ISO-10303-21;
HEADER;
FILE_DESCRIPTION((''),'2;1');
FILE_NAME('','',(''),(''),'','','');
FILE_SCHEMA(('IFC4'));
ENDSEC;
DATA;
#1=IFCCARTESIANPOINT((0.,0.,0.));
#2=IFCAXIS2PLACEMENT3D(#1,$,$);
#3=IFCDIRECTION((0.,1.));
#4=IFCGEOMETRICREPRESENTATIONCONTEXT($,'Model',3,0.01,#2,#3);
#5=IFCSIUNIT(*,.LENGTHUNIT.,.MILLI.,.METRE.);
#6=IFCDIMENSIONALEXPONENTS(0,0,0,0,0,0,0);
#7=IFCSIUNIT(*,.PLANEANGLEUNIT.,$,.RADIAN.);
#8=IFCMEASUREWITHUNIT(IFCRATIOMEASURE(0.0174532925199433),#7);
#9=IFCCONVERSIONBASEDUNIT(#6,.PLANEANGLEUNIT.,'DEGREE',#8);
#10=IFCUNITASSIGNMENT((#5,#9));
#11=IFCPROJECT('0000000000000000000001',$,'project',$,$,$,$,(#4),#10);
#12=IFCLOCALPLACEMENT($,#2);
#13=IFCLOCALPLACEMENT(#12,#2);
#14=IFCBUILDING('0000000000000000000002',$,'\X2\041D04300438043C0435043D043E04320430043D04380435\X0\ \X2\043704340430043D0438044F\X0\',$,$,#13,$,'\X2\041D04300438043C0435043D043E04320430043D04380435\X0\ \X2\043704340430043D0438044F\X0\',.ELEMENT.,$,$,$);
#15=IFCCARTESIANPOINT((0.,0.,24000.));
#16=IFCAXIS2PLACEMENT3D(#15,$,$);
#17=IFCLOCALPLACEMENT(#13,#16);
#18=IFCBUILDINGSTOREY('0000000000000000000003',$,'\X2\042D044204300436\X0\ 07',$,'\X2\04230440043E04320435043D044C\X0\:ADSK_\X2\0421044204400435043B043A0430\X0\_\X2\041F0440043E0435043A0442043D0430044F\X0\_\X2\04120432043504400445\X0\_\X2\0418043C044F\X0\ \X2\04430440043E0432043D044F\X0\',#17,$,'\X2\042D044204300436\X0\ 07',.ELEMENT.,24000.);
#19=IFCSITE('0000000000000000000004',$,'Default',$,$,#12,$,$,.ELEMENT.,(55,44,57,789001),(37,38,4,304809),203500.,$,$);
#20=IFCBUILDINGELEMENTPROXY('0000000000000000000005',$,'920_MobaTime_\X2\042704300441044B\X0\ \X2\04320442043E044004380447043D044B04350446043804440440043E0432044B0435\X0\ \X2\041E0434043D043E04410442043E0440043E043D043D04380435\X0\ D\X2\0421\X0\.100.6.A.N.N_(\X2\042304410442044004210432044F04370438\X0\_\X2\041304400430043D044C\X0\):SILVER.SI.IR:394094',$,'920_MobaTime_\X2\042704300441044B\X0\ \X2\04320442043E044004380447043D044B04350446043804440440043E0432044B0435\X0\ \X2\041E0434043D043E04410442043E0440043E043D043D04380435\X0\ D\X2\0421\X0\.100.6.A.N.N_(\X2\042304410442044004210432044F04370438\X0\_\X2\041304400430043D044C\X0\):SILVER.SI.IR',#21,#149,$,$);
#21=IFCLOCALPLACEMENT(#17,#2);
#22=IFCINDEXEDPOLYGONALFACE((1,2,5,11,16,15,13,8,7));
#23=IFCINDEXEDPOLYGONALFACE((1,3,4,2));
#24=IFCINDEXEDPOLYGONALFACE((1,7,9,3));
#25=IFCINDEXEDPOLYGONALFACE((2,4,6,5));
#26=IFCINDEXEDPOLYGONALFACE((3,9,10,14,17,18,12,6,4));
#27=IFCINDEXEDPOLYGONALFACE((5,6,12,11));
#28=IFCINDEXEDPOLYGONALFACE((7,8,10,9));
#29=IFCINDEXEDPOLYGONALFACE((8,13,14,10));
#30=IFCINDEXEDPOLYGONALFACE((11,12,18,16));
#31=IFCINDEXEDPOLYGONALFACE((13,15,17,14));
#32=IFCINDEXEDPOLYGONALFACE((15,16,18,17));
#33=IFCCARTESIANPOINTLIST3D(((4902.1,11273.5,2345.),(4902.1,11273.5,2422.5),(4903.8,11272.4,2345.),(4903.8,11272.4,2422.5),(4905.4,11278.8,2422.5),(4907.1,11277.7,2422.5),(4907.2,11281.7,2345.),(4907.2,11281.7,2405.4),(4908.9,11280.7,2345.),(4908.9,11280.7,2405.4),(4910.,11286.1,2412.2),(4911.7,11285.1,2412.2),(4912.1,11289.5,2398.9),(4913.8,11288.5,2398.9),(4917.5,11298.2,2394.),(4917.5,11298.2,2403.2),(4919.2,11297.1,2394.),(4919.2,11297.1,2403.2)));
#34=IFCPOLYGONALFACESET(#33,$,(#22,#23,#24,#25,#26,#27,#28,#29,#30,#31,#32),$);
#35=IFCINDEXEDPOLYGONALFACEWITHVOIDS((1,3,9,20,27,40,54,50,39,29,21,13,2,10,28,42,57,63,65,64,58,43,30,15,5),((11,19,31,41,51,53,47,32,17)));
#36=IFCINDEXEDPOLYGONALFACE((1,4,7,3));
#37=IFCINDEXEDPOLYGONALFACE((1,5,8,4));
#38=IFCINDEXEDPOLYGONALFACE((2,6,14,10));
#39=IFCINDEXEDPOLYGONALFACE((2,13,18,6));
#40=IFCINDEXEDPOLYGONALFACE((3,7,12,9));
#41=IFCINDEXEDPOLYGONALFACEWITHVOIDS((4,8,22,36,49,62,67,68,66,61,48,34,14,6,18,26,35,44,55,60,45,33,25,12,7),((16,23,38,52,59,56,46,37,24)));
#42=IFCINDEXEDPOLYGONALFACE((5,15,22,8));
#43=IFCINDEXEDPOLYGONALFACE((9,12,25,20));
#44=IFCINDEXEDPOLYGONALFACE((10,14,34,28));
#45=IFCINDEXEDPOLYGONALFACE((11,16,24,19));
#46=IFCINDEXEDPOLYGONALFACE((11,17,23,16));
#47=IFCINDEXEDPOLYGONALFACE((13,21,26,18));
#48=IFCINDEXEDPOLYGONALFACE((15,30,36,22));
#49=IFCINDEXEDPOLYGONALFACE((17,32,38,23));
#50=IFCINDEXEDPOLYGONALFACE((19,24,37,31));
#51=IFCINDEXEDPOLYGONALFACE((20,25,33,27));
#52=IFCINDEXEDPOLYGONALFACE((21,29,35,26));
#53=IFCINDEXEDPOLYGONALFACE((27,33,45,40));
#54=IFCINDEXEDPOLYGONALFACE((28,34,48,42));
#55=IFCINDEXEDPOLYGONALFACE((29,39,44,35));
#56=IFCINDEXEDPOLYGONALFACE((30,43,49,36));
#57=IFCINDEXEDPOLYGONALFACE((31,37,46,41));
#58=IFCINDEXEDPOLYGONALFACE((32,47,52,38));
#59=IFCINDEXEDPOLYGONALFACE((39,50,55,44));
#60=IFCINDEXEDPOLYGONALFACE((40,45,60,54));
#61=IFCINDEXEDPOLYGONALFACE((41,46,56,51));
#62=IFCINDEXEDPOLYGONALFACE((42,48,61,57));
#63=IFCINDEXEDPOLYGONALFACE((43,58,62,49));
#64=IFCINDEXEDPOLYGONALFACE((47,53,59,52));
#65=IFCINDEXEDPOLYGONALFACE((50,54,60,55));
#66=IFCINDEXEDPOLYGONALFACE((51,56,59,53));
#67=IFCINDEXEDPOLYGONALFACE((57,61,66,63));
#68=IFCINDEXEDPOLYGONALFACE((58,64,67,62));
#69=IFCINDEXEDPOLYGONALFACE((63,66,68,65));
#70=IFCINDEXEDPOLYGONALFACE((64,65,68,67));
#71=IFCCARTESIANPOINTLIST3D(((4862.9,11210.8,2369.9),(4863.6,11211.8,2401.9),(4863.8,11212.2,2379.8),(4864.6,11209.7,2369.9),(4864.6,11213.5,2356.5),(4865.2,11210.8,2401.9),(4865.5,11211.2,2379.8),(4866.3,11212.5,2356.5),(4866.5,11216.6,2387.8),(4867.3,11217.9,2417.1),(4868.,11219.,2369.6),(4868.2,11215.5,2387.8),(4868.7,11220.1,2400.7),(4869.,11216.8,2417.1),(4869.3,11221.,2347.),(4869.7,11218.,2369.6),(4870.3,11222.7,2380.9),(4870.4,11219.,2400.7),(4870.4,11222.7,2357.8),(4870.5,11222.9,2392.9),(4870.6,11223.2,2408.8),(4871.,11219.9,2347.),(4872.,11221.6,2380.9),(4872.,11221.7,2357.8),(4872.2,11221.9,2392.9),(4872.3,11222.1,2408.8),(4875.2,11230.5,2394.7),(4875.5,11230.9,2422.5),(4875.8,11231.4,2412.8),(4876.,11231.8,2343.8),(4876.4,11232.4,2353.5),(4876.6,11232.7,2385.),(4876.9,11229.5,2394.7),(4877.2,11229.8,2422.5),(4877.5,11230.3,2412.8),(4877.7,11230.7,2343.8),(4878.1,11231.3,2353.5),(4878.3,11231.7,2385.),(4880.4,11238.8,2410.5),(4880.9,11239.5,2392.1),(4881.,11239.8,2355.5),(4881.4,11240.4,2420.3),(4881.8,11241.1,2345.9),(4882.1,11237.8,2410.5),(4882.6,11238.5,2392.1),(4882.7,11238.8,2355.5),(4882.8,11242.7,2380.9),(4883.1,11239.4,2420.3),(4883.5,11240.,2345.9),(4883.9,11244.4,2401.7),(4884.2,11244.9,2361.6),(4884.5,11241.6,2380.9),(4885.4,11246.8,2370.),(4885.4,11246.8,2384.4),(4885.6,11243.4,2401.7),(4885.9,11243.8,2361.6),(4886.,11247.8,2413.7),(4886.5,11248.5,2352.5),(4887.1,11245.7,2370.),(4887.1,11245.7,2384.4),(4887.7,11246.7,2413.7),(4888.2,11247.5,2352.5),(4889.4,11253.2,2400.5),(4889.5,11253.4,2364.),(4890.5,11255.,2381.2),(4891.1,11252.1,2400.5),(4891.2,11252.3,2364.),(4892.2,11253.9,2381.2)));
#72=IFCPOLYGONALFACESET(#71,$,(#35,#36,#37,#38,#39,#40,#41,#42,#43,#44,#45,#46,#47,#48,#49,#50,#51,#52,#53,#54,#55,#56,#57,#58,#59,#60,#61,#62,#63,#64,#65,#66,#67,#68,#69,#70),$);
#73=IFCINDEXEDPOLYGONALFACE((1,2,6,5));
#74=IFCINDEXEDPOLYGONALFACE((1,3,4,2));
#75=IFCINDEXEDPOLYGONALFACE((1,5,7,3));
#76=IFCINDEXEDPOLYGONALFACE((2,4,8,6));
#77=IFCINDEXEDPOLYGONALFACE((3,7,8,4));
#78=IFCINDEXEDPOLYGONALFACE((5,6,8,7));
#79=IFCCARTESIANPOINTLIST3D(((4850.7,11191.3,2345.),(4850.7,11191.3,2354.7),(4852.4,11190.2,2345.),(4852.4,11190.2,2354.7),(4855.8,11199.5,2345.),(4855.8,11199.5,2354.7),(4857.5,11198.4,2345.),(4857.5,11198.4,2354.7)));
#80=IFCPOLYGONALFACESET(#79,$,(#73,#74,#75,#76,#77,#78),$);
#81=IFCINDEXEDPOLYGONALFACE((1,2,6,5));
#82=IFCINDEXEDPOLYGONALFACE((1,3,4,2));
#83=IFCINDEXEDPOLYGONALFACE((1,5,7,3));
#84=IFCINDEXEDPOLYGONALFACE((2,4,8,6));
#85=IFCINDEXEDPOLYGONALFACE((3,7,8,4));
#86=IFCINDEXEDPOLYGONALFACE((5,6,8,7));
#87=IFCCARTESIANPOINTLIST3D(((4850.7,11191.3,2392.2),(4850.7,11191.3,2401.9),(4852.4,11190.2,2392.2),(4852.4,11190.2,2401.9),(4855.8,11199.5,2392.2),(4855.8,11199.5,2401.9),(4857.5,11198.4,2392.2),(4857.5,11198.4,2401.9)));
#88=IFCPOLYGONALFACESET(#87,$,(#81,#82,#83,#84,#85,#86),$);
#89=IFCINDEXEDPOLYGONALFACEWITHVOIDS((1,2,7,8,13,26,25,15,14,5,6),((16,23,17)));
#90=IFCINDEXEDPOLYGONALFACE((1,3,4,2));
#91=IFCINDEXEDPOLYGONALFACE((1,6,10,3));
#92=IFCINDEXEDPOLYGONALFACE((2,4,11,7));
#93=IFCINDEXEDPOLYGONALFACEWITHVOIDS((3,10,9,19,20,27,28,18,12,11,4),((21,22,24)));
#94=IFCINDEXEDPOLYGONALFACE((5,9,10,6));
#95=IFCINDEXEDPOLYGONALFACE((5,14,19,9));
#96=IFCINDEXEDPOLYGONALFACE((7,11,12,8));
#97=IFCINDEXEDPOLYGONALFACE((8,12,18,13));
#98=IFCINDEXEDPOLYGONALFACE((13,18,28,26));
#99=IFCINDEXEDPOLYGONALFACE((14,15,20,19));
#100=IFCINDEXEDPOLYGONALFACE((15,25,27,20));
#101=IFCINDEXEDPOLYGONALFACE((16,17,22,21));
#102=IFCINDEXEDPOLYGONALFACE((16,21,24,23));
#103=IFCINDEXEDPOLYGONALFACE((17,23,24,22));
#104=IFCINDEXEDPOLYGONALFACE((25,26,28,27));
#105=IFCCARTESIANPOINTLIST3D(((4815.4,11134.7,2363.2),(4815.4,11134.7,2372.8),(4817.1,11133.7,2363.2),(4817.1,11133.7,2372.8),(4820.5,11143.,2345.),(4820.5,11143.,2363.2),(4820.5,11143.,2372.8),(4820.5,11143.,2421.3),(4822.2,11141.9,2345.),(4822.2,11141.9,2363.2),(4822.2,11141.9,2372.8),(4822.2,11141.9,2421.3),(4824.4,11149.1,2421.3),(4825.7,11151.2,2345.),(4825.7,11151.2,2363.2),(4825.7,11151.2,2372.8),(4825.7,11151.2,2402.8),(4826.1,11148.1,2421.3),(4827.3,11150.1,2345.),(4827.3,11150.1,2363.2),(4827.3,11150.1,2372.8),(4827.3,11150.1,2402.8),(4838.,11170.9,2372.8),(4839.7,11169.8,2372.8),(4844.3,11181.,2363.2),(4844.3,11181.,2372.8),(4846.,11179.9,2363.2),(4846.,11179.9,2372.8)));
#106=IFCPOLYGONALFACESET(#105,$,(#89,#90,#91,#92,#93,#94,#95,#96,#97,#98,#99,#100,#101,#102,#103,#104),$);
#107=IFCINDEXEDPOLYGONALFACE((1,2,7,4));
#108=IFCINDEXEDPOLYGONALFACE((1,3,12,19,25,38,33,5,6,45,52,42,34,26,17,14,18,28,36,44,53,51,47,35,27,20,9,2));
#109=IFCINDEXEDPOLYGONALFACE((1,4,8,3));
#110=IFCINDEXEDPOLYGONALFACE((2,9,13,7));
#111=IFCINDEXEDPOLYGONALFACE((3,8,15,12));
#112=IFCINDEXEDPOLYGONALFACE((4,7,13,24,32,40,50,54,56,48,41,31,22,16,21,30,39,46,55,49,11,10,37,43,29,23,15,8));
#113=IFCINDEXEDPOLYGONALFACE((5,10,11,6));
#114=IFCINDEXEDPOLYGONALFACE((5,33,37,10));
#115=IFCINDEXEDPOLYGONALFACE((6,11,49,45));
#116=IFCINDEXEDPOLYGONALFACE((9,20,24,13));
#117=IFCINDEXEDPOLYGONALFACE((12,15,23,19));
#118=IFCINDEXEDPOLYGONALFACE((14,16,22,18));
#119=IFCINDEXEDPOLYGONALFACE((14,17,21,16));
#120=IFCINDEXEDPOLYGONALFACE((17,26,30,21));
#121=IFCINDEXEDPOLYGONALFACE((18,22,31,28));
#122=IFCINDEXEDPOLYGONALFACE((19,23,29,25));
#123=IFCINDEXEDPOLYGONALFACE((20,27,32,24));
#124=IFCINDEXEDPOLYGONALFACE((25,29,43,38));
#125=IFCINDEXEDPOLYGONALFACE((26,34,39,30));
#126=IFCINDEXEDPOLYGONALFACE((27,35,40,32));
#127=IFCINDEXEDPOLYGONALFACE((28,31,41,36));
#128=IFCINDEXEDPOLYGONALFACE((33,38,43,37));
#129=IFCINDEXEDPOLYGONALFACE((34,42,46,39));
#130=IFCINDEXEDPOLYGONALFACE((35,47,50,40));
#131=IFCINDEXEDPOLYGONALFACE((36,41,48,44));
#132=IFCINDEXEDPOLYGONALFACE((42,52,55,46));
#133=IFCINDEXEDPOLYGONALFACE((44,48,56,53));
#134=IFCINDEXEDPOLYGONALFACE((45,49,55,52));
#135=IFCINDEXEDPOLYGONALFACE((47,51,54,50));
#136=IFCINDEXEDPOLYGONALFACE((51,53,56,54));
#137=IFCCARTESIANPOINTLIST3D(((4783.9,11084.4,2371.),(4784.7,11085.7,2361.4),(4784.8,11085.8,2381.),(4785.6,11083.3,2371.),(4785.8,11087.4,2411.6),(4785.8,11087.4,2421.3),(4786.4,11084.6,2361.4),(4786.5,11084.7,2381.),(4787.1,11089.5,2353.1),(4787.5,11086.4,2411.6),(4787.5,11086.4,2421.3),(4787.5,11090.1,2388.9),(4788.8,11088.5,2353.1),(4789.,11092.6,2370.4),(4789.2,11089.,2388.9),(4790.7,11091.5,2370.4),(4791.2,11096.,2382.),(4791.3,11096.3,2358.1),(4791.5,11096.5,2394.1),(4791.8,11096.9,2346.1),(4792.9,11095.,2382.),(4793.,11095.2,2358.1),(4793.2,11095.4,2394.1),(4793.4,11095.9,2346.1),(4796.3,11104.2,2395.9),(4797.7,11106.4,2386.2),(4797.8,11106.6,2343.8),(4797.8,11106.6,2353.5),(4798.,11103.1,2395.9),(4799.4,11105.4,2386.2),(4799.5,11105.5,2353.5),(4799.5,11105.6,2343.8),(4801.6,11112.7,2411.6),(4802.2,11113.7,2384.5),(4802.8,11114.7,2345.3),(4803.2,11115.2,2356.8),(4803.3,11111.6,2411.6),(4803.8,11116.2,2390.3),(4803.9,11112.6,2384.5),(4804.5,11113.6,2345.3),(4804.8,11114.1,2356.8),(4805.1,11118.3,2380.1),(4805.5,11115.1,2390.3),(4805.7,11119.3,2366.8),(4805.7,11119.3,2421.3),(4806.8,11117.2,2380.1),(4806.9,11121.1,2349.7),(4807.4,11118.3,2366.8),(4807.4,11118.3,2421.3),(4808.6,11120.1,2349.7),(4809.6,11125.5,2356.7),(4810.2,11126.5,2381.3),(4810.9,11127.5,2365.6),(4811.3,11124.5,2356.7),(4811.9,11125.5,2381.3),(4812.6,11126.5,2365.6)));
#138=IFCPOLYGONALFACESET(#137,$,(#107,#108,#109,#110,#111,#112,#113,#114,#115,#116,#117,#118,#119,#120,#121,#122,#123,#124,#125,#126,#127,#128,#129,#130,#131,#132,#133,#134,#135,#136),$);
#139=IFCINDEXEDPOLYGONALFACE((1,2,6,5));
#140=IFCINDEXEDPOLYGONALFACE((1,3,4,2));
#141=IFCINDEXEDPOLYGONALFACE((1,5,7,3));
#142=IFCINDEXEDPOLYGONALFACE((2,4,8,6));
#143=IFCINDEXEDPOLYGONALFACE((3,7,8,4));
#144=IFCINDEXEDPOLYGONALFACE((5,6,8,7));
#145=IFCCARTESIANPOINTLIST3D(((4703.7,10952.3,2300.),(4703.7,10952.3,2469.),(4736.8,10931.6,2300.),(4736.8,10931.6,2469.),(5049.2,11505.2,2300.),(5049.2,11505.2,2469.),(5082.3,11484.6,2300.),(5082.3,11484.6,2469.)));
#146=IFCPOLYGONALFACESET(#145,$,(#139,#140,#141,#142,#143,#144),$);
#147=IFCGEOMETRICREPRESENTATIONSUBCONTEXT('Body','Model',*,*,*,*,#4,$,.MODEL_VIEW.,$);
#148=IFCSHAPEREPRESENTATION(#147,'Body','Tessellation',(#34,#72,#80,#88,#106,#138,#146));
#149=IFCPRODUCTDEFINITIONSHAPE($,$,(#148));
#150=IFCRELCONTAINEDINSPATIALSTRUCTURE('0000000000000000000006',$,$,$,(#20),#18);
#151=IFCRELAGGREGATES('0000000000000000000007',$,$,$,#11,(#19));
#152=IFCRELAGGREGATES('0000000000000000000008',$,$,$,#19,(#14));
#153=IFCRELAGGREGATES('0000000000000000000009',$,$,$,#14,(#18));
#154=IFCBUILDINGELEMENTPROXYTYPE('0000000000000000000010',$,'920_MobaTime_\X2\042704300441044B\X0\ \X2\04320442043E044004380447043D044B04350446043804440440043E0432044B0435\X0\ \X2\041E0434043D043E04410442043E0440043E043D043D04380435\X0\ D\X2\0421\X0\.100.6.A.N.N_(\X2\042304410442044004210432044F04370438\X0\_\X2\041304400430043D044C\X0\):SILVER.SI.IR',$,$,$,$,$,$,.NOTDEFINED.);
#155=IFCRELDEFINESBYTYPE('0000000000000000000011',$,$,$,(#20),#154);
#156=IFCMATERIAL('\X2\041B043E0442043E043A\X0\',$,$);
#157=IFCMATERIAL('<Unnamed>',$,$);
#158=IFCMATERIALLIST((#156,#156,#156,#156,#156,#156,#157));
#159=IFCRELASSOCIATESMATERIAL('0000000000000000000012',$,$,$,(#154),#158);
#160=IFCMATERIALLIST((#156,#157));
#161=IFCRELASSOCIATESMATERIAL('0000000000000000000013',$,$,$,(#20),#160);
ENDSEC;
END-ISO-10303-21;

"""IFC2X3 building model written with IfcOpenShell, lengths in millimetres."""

from ifc_helpers import new_model, entity, si_unit, converted_unit, direction, frame, origin, origin_2d_with_axis, place, context, subcontext, project, spatial, polyline, rectangle, outline, extrude, source, transform, mapped, material, material_list, type_object, type_shapes, element, save


model = new_model("IFC2X3")

# Units and contexts
model_context = context("Model", 3, precision=0.01, world=origin(), true_north=direction((0.0, 1.0)))
body_context = subcontext(model_context, "Body", "Model", "MODEL_VIEW")
ifc_project = project(units=[si_unit("LENGTHUNIT", "METRE", prefix="MILLI"), converted_unit("PLANEANGLEUNIT", "DEGREE", entity("IfcRatioMeasure", 0.0174532925199433), si_unit("PLANEANGLEUNIT", "RADIAN"), dimensions=[0, 0, 0, 0, 0, 0, 0])], contexts=[model_context])

# Site, building, storey
site_placement = place(None, frame((0.0, 0.0, 0.0)))
site = spatial("IfcSite", under=ifc_project, at=site_placement, Name="Default", CompositionType="ELEMENT", RefLatitude=(55, 44, 57, 789001), RefLongitude=(37, 38, 4, 304809), RefElevation=203500.0)
building_placement = place(site_placement, origin())
building = spatial("IfcBuilding", under=site, at=building_placement, Name="Наименование здания", LongName="Наименование здания", CompositionType="ELEMENT")
storey_placement = place(building_placement, frame((0.0, 0.0, 24000.0)))
storey = spatial("IfcBuildingStorey", under=building, at=storey_placement, Name="Этаж 07", ObjectType="Уровень:ADSK_Стрелка_Проектная_Вверх_Имя уровня", LongName="Этаж 07", CompositionType="ELEMENT", Elevation=24000.0)

# Building element proxy
ifc_material_1 = material(Name="Лоток")
ifc_material_2 = material(Name="<Unnamed>")
ifc_material_list_1 = material_list([ifc_material_1, ifc_material_2])
ifc_material_list_2 = material_list([ifc_material_1, ifc_material_1, ifc_material_1, ifc_material_1, ifc_material_1, ifc_material_1, ifc_material_2])
building_element_proxy_type = type_object("IfcBuildingElementProxyType", Name="920_MobaTime_Часы вторичныецифровые Односторонние DС.100.6.A.N.N_(УстрСвязи_Грань):SILVER.SI.IR", PredefinedType="NOTDEFINED", material=ifc_material_list_2)
shared_shape = source(origin(), body_context, "Body", "SweptSolid", [
    extrude(outline(polyline([(-49.3, -13.1), (28.2, -13.1), (28.2, -6.8), (17.9, 1.8), (8.9, 16.0), (-0.3, 16.0), (4.6, 5.8), (11.1, -3.4), (-49.3, -3.4), (-49.3, -13.1)])), frame((-64.6, 9.8, 39.0), z_axis=(0.0, 0.0, 1.0), x_axis=(0.0, 1.0, 0.0)), (0.0, 0.0, 1.0), 2.0),
    extrude(outline(polyline([(2.2, -27.6), (19.0, -27.6), (30.5, -16.1), (33.3, -4.9), (31.0, 5.8), (21.8, 17.2), (5.2, 27.3), (-11.1, 33.0), (-24.0, 32.7), (-33.6, 27.6), (-40.3, 18.6), (-42.8, 5.7), (-38.0, -6.3), (-27.2, -15.0), (-17.5, -17.7), (-8.2, -16.4), (-0.3, -11.9), (5.1, -4.5), (7.3, 6.2), (4.0, 17.2), (18.5, 7.3), (23.6, -2.4), (22.0, -11.4), (14.2, -18.4), (5.3, -18.3), (2.2, -27.6)]), holes=[polyline([(-9.0, 23.3), (-1.3, 14.4), (-2.6, 2.0), (-11.4, -7.0), (-23.4, -6.1), (-32.2, 2.9), (-31.2, 15.1), (-25.6, 22.1), (-17.5, 24.9), (-9.0, 23.3)])]), frame((-2.7, 3.6, 39.0), z_axis=(0.0, 0.0, 1.0), x_axis=(-0.427649, 0.903945, 0.0)), (0.0, 0.0, 1.0), 2.0),
    extrude(rectangle(XDim=9.7, YDim=9.7, at=origin_2d_with_axis()), frame((40.6, -34.7, 39.0)), (0.0, 0.0, 1.0), 2.0),
    extrude(rectangle(XDim=9.7, YDim=9.7, at=origin_2d_with_axis()), frame((40.6, 12.6, 39.0)), (0.0, 0.0, 1.0), 2.0),
    extrude(outline(polyline([(-0.9, -28.1), (8.8, -28.1), (8.8, -9.9), (18.5, -9.9), (18.5, -0.2), (8.8, -0.2), (8.8, 48.3), (1.5, 48.3), (-36.0, -0.2), (-36.0, -9.9), (-0.9, -9.9), (-0.9, -28.1)]), holes=[polyline([(-0.9, -0.2), (-24.1, -0.2), (-0.9, 29.7), (-0.9, -0.2)])]), frame((93.6, -11.4, 39.0)), (0.0, 0.0, 1.0), 2.0),
    extrude(outline(polyline([(3.3, -28.3), (12.5, -28.3), (20.5, -25.0), (26.8, -18.8), (30.7, -10.0), (31.4, 1.6), (26.9, 11.8), (20.1, 18.4), (11.1, 22.3), (1.0, 23.3), (-7.9, 20.4), (-14.9, 14.5), (-18.9, 6.2), (-17.1, -9.0), (-36.7, 0.5), (-29.1, 29.3), (-38.5, 31.7), (-48.1, -4.6), (-11.6, -23.0), (-8.0, -14.0), (-10.8, -7.6), (-10.2, 1.1), (-3.0, 11.8), (9.2, 12.8), (20.0, 5.4), (21.3, -7.5), (15.5, -16.4), (4.6, -18.6), (3.3, -28.3)])), frame((147.1, -8.5, 39.0), z_axis=(0.0, 0.0, 1.0), x_axis=(0.256974, -0.966418, 0.0)), (0.0, 0.0, 1.0), 2.0),
    extrude(rectangle(XDim=652.0, YDim=169.0, at=origin_2d_with_axis()), frame((0.0, 0.0, 0.0), z_axis=(0.0, 0.0, 1.0), x_axis=(-1.0, 0.0, 0.0)), (0.0, 0.0, 1.0), 39.0),
])
type_shapes(building_element_proxy_type, [shared_shape])
proxy_1_placement = place(storey_placement, frame((4909.6, 11208.1, 2384.5), z_axis=(-0.848048, 0.52992, 0.0), x_axis=(-0.52992, -0.848048, 0.0)))
element("IfcBuildingElementProxy", 1, at=proxy_1_placement, inside=storey, type_object=building_element_proxy_type, material=ifc_material_list_1, Name="920_MobaTime_Часы вторичныецифровые Односторонние DС.100.6.A.N.N_(УстрСвязи_Грань):SILVER.SI.IR:394094", ObjectType="920_MobaTime_Часы вторичныецифровые Односторонние DС.100.6.A.N.N_(УстрСвязи_Грань):SILVER.SI.IR", context=body_context, shape_type="MappedRepresentation", body=[
    mapped(shared_shape, transform((0.0, 0.0, 0.0), scale=1.0)),
])

save(model, "model.ifc")
